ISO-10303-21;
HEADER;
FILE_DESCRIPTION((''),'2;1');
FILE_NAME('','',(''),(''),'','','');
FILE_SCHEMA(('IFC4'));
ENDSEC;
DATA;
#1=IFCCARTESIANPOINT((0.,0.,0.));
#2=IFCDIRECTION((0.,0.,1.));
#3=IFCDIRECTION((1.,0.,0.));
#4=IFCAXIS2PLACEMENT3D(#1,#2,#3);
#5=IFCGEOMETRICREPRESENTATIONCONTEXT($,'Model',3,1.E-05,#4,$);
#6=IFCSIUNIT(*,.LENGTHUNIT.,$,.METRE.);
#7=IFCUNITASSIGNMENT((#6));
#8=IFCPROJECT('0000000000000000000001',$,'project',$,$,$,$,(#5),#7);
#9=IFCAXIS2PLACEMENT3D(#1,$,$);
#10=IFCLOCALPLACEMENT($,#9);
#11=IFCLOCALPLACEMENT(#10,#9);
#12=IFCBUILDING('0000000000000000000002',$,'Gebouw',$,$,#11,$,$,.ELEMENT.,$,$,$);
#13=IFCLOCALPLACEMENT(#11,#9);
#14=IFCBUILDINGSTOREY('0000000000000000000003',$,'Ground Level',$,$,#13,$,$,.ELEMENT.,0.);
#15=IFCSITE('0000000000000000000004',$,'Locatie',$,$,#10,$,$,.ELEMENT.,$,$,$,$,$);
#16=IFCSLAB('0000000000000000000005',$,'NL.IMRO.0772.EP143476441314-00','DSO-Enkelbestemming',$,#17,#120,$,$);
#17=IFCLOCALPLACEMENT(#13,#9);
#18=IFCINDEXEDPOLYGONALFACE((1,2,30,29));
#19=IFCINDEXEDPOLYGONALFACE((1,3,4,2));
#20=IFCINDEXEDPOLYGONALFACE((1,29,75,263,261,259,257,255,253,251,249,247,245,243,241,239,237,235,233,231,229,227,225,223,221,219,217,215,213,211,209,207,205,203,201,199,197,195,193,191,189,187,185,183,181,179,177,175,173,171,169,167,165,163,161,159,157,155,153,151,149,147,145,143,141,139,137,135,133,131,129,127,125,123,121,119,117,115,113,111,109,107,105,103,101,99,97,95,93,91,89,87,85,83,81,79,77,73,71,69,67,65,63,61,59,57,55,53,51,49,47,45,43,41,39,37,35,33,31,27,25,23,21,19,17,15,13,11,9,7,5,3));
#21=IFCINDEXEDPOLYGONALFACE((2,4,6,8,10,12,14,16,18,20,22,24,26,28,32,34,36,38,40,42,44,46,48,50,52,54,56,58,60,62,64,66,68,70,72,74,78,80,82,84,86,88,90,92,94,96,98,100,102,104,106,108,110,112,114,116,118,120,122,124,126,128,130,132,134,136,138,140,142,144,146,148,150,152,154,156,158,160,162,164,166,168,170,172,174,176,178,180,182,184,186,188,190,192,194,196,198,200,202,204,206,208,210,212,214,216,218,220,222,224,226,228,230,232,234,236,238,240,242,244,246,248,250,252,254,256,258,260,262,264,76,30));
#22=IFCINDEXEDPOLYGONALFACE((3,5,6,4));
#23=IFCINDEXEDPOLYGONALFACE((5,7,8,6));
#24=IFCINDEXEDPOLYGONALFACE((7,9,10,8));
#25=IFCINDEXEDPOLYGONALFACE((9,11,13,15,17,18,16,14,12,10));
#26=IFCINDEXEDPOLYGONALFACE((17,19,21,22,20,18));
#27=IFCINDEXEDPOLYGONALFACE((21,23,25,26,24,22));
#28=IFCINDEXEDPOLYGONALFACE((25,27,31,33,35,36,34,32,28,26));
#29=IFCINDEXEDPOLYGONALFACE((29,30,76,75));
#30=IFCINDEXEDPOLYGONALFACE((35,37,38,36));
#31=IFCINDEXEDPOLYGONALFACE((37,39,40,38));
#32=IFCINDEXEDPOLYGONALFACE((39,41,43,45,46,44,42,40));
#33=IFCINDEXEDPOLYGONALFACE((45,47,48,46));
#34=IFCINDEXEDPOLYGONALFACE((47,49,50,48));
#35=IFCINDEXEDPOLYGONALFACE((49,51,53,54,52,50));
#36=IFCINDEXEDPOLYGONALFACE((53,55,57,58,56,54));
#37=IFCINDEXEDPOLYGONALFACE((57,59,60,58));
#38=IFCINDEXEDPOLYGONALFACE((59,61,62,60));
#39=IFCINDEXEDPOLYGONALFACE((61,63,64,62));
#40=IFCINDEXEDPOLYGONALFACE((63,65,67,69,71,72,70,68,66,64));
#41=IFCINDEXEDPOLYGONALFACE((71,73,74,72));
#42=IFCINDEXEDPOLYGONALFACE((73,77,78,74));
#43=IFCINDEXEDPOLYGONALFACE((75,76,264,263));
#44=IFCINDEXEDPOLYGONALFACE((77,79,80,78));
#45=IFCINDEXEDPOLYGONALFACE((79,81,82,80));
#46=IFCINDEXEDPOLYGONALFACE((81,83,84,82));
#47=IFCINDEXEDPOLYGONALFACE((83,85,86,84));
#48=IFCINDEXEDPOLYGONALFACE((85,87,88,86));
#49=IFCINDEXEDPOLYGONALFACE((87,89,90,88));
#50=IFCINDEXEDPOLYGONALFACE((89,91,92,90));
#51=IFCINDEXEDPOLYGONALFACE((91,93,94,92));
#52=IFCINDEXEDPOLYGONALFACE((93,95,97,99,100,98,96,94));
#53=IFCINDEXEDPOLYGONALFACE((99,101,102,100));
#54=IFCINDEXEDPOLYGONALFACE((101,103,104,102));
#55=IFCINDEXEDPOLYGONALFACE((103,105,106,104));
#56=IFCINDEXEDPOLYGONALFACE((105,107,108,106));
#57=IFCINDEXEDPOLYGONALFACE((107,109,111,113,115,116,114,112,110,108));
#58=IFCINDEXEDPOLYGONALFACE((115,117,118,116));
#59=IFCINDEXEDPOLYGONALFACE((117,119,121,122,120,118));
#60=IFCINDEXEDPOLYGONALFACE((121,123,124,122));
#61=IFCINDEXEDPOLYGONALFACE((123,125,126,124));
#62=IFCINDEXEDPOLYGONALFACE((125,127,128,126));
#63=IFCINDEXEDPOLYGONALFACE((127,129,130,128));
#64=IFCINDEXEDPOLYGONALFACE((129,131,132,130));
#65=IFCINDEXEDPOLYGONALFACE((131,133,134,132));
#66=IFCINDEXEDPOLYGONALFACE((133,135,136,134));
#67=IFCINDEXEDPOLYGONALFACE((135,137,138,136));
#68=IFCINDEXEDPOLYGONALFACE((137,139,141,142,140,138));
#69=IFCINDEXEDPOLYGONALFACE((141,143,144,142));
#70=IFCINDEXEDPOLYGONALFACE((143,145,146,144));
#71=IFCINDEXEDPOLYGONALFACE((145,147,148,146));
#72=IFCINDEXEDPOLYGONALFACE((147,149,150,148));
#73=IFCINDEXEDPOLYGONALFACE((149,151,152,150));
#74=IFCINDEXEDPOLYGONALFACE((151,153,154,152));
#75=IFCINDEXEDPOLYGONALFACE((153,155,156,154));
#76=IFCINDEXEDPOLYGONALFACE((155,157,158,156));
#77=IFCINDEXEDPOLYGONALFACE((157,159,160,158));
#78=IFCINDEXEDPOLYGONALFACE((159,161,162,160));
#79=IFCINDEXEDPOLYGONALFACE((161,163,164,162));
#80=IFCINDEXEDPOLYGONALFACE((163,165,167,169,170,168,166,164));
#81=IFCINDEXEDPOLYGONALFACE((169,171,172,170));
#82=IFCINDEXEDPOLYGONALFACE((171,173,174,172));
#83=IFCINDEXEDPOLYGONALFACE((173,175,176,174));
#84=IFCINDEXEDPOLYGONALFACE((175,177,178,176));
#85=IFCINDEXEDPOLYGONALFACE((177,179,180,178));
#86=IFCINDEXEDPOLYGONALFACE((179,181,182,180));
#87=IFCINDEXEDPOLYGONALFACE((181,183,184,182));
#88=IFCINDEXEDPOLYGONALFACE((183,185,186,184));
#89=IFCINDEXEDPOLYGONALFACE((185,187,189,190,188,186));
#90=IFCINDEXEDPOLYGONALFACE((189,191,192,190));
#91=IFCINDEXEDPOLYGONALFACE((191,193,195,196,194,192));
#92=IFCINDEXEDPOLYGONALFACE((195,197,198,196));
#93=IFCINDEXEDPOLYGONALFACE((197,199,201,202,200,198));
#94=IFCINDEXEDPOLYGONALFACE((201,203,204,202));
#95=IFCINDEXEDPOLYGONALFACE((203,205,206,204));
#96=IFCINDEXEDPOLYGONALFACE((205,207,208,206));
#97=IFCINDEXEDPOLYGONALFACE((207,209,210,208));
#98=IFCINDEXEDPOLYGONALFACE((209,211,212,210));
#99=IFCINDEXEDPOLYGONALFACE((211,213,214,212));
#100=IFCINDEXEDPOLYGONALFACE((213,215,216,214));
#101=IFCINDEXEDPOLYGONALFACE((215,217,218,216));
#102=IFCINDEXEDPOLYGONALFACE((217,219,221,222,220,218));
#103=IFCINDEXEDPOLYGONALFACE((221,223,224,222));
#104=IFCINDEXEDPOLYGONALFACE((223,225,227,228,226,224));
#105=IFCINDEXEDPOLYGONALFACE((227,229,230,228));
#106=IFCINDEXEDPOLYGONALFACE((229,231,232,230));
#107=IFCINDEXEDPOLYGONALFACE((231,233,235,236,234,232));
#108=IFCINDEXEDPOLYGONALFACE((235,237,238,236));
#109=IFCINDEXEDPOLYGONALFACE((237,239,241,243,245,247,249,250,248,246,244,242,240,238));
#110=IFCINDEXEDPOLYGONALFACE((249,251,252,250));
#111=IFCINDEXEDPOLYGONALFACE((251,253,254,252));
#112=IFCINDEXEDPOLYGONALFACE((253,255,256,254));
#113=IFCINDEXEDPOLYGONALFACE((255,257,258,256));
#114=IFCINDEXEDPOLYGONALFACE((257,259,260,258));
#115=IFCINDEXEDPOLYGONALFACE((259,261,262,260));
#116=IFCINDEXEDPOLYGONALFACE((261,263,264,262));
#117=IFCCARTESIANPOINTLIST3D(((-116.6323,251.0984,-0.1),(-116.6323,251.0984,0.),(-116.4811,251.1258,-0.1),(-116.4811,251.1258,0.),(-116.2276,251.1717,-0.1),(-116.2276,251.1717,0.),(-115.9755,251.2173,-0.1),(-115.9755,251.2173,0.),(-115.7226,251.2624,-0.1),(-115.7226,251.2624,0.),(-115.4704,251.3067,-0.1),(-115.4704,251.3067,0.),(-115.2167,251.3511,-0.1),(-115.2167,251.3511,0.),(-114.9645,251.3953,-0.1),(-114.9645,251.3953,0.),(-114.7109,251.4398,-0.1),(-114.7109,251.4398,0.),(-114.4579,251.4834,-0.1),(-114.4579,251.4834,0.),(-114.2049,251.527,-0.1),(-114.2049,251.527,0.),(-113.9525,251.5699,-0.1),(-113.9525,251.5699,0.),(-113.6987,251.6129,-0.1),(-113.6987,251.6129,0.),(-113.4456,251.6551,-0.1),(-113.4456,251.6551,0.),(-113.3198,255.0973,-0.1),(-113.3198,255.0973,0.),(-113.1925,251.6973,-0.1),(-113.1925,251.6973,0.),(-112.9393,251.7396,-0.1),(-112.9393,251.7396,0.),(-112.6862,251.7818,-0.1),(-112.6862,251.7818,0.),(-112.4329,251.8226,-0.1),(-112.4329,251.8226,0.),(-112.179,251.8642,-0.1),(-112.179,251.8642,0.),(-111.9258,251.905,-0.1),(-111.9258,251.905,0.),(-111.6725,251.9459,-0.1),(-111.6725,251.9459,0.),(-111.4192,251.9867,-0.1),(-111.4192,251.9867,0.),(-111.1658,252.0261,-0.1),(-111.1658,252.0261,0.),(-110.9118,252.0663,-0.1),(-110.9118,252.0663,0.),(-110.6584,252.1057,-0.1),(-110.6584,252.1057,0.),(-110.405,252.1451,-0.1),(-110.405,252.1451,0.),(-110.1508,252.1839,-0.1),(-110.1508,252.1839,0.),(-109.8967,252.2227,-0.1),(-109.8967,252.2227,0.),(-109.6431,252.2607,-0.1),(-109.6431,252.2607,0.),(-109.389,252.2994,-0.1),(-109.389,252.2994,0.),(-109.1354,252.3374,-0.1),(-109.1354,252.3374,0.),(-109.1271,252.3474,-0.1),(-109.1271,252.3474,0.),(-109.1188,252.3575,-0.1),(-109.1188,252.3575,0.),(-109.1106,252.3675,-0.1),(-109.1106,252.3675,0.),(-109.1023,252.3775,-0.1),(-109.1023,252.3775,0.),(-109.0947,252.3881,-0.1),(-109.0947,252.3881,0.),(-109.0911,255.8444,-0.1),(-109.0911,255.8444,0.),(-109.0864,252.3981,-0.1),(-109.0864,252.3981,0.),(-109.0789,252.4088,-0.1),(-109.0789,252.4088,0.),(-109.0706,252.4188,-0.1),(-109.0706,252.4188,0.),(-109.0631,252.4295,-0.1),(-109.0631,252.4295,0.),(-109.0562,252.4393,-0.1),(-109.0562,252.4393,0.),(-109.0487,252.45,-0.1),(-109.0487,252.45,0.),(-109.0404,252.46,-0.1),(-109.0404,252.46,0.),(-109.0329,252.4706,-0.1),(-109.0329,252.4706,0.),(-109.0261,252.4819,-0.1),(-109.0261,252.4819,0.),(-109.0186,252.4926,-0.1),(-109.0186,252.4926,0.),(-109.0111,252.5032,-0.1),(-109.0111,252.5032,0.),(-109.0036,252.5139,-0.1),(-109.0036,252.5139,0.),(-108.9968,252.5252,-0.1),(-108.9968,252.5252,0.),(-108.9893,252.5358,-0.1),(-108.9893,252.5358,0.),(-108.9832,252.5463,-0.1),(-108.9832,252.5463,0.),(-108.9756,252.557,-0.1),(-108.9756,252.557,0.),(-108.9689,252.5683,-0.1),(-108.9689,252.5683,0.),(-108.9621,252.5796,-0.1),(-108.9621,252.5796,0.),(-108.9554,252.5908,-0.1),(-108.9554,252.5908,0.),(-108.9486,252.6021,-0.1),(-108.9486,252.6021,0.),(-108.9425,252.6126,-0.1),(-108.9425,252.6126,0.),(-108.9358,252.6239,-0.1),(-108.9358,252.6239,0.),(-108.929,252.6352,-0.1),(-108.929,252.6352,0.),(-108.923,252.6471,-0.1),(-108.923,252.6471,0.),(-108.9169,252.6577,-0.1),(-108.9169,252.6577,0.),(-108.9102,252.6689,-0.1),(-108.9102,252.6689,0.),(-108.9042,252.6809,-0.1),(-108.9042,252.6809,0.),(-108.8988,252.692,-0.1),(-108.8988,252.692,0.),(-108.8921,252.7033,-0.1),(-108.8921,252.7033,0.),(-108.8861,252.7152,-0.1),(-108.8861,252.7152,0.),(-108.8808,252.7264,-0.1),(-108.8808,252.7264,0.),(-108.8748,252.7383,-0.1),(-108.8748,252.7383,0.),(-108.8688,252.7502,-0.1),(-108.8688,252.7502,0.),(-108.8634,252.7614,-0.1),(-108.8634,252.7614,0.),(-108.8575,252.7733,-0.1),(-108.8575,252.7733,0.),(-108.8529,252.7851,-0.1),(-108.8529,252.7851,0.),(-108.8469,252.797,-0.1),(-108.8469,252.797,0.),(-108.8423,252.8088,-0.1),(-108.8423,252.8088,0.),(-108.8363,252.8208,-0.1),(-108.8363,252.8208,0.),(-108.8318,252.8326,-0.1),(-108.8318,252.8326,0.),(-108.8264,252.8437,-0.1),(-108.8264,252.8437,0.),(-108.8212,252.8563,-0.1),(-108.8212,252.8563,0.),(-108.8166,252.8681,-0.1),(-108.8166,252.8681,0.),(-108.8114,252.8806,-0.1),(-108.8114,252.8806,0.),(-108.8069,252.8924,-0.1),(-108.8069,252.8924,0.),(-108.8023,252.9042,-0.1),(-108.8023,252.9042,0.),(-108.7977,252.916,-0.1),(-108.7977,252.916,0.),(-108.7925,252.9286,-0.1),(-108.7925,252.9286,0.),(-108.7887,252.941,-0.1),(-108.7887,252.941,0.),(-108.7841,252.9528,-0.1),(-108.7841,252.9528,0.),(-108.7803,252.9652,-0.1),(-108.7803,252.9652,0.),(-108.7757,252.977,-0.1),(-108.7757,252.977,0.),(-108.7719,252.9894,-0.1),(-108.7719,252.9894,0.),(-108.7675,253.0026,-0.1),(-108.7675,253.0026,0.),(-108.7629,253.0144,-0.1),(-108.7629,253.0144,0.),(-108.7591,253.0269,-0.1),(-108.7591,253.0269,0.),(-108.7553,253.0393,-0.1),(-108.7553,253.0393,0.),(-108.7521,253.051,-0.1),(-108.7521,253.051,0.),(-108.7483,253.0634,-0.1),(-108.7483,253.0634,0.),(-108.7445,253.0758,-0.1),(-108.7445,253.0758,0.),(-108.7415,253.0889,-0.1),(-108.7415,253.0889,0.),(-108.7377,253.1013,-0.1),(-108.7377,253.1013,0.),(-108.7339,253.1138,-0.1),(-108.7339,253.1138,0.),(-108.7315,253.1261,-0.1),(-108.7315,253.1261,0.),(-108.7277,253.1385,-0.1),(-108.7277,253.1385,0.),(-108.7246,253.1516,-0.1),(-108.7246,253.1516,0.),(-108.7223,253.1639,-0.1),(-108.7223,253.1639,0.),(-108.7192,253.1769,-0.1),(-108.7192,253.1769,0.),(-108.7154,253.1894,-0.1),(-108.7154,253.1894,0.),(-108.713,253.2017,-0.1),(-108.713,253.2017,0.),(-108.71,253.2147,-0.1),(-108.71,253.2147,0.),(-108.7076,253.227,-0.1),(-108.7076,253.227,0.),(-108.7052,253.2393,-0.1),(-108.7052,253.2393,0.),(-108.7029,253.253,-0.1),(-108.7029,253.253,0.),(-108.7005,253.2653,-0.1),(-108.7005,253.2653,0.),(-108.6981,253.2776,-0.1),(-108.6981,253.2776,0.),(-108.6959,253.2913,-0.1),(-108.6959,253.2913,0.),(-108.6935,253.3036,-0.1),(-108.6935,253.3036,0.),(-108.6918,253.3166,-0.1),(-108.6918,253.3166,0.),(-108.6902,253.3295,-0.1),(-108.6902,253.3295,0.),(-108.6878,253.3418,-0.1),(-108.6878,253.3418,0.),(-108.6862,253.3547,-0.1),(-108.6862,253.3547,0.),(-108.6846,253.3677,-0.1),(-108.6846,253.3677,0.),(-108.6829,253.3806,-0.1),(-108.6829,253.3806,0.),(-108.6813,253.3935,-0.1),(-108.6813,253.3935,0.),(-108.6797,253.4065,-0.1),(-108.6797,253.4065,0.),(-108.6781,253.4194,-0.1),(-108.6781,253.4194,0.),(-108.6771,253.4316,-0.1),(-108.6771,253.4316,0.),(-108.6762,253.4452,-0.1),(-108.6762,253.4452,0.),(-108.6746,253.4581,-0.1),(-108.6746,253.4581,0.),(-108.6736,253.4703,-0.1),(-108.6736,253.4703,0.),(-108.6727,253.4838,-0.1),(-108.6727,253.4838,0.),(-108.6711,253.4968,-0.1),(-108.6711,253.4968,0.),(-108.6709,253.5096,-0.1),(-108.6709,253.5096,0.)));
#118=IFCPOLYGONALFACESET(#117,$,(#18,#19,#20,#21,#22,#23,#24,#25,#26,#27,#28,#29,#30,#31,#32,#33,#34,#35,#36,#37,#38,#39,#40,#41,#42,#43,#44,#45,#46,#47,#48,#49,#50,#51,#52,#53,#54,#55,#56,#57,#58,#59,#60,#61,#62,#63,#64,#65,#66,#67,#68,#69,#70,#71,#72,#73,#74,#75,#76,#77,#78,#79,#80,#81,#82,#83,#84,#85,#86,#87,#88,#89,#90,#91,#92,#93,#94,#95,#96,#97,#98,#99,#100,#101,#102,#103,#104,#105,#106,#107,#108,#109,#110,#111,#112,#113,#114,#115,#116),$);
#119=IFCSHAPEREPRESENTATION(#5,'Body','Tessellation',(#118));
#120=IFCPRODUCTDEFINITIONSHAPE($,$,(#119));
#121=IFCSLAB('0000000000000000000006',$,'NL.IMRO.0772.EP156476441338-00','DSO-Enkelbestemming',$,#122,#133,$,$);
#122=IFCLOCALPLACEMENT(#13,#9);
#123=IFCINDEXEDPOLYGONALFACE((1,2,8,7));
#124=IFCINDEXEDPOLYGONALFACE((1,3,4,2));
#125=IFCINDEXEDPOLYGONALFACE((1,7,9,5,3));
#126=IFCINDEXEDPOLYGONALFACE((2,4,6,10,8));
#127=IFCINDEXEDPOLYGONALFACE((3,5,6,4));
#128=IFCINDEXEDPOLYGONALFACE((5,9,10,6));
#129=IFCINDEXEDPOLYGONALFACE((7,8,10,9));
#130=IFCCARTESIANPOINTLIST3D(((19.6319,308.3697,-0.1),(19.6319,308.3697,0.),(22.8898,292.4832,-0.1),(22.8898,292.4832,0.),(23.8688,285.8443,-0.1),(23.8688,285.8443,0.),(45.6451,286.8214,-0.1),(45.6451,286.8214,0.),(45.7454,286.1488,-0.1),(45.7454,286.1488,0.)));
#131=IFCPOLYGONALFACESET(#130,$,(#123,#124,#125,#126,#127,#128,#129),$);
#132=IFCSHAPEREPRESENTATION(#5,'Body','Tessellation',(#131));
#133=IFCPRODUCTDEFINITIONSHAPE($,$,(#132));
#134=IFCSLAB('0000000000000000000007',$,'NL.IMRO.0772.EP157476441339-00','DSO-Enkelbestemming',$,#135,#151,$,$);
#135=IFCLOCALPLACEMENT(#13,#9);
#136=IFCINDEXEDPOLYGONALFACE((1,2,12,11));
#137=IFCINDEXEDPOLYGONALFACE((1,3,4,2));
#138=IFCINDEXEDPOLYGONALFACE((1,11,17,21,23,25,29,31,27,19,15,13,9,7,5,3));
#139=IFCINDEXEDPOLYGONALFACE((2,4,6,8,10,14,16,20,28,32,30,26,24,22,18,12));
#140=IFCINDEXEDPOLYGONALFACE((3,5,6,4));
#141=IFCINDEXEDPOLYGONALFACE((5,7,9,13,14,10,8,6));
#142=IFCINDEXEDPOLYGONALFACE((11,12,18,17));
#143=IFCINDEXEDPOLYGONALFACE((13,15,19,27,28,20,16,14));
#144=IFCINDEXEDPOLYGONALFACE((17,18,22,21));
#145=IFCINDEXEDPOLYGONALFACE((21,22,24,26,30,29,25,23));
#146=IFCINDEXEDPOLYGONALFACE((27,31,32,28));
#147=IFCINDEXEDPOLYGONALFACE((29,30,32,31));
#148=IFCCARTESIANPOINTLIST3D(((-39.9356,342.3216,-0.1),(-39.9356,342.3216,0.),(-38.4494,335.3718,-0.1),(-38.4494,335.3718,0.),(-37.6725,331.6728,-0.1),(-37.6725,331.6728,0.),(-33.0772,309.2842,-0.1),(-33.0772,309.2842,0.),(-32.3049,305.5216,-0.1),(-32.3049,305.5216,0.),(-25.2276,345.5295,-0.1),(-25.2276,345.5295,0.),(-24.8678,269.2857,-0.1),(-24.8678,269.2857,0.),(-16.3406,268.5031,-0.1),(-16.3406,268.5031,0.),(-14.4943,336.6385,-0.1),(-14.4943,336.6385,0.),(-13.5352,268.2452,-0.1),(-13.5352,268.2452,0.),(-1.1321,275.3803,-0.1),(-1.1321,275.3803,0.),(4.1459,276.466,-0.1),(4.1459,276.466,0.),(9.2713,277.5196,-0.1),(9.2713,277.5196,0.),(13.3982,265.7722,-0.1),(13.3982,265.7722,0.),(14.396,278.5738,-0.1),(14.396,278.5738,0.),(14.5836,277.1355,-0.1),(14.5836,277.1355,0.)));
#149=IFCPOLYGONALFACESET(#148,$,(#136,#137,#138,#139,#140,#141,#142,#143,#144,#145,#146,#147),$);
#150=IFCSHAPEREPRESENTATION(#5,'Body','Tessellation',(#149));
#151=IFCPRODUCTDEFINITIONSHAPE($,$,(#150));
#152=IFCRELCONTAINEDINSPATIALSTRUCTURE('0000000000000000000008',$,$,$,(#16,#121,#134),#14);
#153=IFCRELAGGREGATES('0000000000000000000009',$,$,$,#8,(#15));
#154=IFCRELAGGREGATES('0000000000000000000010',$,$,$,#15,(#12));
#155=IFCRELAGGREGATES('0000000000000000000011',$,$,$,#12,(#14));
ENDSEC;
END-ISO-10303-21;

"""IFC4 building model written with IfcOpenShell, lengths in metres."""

from ifc_helpers import new_model, si_unit, frame, origin, origin_with_axes, place, context, project, spatial, polyline, outline, extrude, element, save


model = new_model("IFC4")

# Units and contexts
model_context = context("Model", 3, precision=1e-05, world=origin_with_axes())
ifc_project = project(units=[si_unit("LENGTHUNIT", "METRE")], contexts=[model_context])

# Site, building, storey
site_placement = place(None, origin())
site = spatial("IfcSite", under=ifc_project, at=site_placement, Name="Locatie", CompositionType="ELEMENT")
building_placement = place(site_placement, origin())
building = spatial("IfcBuilding", under=site, at=building_placement, Name="Gebouw", CompositionType="ELEMENT")
storey_placement = place(building_placement, origin())
storey = spatial("IfcBuildingStorey", under=building, at=storey_placement, Name="Ground Level", CompositionType="ELEMENT", Elevation=0.0)

# Slabs
slab_1_placement = place(storey_placement, origin())
element("IfcSlab", 1, at=slab_1_placement, inside=storey, Name="NL.IMRO.0772.EP143476441314-00", Description="DSO-Enkelbestemming", context=model_context, shape_type="SweptSolid", body=[
    extrude(outline(polyline([(-109.0911, 255.8444), (-108.6709, 253.5096), (-108.6711, 253.4968), (-108.6727, 253.4838), (-108.6736, 253.4703), (-108.6746, 253.4581), (-108.6762, 253.4452), (-108.6771, 253.4316), (-108.6781, 253.4194), (-108.6797, 253.4065), (-108.6813, 253.3935), (-108.6829, 253.3806), (-108.6846, 253.3677), (-108.6862, 253.3547), (-108.6878, 253.3418), (-108.6902, 253.3295), (-108.6918, 253.3166), (-108.6935, 253.3036), (-108.6959, 253.2913), (-108.6981, 253.2776), (-108.7005, 253.2653), (-108.7029, 253.253), (-108.7052, 253.2393), (-108.7076, 253.227), (-108.71, 253.2147), (-108.713, 253.2017), (-108.7154, 253.1894), (-108.7192, 253.1769), (-108.7223, 253.1639), (-108.7246, 253.1516), (-108.7277, 253.1385), (-108.7315, 253.1261), (-108.7339, 253.1138), (-108.7377, 253.1013), (-108.7415, 253.0889), (-108.7445, 253.0758), (-108.7483, 253.0634), (-108.7521, 253.051), (-108.7553, 253.0393), (-108.7591, 253.0269), (-108.7629, 253.0144), (-108.7675, 253.0026), (-108.7719, 252.9894), (-108.7757, 252.977), (-108.7803, 252.9652), (-108.7841, 252.9528), (-108.7887, 252.941), (-108.7925, 252.9286), (-108.7977, 252.916), (-108.8023, 252.9042), (-108.8069, 252.8924), (-108.8114, 252.8806), (-108.8166, 252.8681), (-108.8212, 252.8563), (-108.8264, 252.8437), (-108.8318, 252.8326), (-108.8363, 252.8208), (-108.8423, 252.8088), (-108.8469, 252.797), (-108.8529, 252.7851), (-108.8575, 252.7733), (-108.8634, 252.7614), (-108.8688, 252.7502), (-108.8748, 252.7383), (-108.8808, 252.7264), (-108.8861, 252.7152), (-108.8921, 252.7033), (-108.8988, 252.692), (-108.9042, 252.6809), (-108.9102, 252.6689), (-108.9169, 252.6577), (-108.923, 252.6471), (-108.929, 252.6352), (-108.9358, 252.6239), (-108.9425, 252.6126), (-108.9486, 252.6021), (-108.9554, 252.5908), (-108.9621, 252.5796), (-108.9689, 252.5683), (-108.9756, 252.557), (-108.9832, 252.5463), (-108.9893, 252.5358), (-108.9968, 252.5252), (-109.0036, 252.5139), (-109.0111, 252.5032), (-109.0186, 252.4926), (-109.0261, 252.4819), (-109.0329, 252.4706), (-109.0404, 252.46), (-109.0487, 252.45), (-109.0562, 252.4393), (-109.0631, 252.4295), (-109.0706, 252.4188), (-109.0789, 252.4088), (-109.0864, 252.3981), (-109.0947, 252.3881), (-109.1023, 252.3775), (-109.1106, 252.3675), (-109.1188, 252.3575), (-109.1271, 252.3474), (-109.1354, 252.3374), (-109.389, 252.2994), (-109.6431, 252.2607), (-109.8967, 252.2227), (-110.1508, 252.1839), (-110.405, 252.1451), (-110.6584, 252.1057), (-110.9118, 252.0663), (-111.1658, 252.0261), (-111.4192, 251.9867), (-111.6725, 251.9459), (-111.9258, 251.905), (-112.179, 251.8642), (-112.4329, 251.8226), (-112.6862, 251.7818), (-112.9393, 251.7396), (-113.1925, 251.6973), (-113.4456, 251.6551), (-113.6987, 251.6129), (-113.9525, 251.5699), (-114.2049, 251.527), (-114.4579, 251.4834), (-114.7109, 251.4398), (-114.9645, 251.3953), (-115.2167, 251.3511), (-115.4704, 251.3067), (-115.7226, 251.2624), (-115.9755, 251.2173), (-116.2276, 251.1717), (-116.4811, 251.1258), (-116.6323, 251.0984), (-113.3198, 255.0973), (-109.0911, 255.8444)])), frame((0.0, 0.0, -0.1), z_axis=(0.0, 0.0, 1.0), x_axis=(1.0, 0.0, 0.0)), (0.0, 0.0, 1.0), 0.1),
])
slab_2_placement = place(storey_placement, origin())
element("IfcSlab", 2, at=slab_2_placement, inside=storey, Name="NL.IMRO.0772.EP156476441338-00", Description="DSO-Enkelbestemming", context=model_context, shape_type="SweptSolid", body=[
    extrude(outline(polyline([(45.7454, 286.1488), (23.8688, 285.8443), (22.8898, 292.4832), (19.6319, 308.3697), (45.6451, 286.8214), (45.7454, 286.1488)])), frame((0.0, 0.0, -0.1), z_axis=(0.0, 0.0, 1.0), x_axis=(1.0, 0.0, 0.0)), (0.0, 0.0, 1.0), 0.1),
])
slab_3_placement = place(storey_placement, origin())
element("IfcSlab", 3, at=slab_3_placement, inside=storey, Name="NL.IMRO.0772.EP157476441339-00", Description="DSO-Enkelbestemming", context=model_context, shape_type="SweptSolid", body=[
    extrude(outline(polyline([(-1.1321, 275.3803), (4.1459, 276.466), (9.2713, 277.5196), (14.396, 278.5738), (14.5836, 277.1355), (13.3982, 265.7722), (-13.5352, 268.2452), (-16.3406, 268.5031), (-24.8678, 269.2857), (-32.3049, 305.5216), (-33.0772, 309.2842), (-37.6725, 331.6728), (-38.4494, 335.3718), (-39.9356, 342.3216), (-25.2276, 345.5295), (-14.4943, 336.6385), (-1.1321, 275.3803)])), frame((0.0, 0.0, -0.1), z_axis=(0.0, 0.0, 1.0), x_axis=(1.0, 0.0, 0.0)), (0.0, 0.0, 1.0), 0.1),
])

save(model, "model.ifc")
